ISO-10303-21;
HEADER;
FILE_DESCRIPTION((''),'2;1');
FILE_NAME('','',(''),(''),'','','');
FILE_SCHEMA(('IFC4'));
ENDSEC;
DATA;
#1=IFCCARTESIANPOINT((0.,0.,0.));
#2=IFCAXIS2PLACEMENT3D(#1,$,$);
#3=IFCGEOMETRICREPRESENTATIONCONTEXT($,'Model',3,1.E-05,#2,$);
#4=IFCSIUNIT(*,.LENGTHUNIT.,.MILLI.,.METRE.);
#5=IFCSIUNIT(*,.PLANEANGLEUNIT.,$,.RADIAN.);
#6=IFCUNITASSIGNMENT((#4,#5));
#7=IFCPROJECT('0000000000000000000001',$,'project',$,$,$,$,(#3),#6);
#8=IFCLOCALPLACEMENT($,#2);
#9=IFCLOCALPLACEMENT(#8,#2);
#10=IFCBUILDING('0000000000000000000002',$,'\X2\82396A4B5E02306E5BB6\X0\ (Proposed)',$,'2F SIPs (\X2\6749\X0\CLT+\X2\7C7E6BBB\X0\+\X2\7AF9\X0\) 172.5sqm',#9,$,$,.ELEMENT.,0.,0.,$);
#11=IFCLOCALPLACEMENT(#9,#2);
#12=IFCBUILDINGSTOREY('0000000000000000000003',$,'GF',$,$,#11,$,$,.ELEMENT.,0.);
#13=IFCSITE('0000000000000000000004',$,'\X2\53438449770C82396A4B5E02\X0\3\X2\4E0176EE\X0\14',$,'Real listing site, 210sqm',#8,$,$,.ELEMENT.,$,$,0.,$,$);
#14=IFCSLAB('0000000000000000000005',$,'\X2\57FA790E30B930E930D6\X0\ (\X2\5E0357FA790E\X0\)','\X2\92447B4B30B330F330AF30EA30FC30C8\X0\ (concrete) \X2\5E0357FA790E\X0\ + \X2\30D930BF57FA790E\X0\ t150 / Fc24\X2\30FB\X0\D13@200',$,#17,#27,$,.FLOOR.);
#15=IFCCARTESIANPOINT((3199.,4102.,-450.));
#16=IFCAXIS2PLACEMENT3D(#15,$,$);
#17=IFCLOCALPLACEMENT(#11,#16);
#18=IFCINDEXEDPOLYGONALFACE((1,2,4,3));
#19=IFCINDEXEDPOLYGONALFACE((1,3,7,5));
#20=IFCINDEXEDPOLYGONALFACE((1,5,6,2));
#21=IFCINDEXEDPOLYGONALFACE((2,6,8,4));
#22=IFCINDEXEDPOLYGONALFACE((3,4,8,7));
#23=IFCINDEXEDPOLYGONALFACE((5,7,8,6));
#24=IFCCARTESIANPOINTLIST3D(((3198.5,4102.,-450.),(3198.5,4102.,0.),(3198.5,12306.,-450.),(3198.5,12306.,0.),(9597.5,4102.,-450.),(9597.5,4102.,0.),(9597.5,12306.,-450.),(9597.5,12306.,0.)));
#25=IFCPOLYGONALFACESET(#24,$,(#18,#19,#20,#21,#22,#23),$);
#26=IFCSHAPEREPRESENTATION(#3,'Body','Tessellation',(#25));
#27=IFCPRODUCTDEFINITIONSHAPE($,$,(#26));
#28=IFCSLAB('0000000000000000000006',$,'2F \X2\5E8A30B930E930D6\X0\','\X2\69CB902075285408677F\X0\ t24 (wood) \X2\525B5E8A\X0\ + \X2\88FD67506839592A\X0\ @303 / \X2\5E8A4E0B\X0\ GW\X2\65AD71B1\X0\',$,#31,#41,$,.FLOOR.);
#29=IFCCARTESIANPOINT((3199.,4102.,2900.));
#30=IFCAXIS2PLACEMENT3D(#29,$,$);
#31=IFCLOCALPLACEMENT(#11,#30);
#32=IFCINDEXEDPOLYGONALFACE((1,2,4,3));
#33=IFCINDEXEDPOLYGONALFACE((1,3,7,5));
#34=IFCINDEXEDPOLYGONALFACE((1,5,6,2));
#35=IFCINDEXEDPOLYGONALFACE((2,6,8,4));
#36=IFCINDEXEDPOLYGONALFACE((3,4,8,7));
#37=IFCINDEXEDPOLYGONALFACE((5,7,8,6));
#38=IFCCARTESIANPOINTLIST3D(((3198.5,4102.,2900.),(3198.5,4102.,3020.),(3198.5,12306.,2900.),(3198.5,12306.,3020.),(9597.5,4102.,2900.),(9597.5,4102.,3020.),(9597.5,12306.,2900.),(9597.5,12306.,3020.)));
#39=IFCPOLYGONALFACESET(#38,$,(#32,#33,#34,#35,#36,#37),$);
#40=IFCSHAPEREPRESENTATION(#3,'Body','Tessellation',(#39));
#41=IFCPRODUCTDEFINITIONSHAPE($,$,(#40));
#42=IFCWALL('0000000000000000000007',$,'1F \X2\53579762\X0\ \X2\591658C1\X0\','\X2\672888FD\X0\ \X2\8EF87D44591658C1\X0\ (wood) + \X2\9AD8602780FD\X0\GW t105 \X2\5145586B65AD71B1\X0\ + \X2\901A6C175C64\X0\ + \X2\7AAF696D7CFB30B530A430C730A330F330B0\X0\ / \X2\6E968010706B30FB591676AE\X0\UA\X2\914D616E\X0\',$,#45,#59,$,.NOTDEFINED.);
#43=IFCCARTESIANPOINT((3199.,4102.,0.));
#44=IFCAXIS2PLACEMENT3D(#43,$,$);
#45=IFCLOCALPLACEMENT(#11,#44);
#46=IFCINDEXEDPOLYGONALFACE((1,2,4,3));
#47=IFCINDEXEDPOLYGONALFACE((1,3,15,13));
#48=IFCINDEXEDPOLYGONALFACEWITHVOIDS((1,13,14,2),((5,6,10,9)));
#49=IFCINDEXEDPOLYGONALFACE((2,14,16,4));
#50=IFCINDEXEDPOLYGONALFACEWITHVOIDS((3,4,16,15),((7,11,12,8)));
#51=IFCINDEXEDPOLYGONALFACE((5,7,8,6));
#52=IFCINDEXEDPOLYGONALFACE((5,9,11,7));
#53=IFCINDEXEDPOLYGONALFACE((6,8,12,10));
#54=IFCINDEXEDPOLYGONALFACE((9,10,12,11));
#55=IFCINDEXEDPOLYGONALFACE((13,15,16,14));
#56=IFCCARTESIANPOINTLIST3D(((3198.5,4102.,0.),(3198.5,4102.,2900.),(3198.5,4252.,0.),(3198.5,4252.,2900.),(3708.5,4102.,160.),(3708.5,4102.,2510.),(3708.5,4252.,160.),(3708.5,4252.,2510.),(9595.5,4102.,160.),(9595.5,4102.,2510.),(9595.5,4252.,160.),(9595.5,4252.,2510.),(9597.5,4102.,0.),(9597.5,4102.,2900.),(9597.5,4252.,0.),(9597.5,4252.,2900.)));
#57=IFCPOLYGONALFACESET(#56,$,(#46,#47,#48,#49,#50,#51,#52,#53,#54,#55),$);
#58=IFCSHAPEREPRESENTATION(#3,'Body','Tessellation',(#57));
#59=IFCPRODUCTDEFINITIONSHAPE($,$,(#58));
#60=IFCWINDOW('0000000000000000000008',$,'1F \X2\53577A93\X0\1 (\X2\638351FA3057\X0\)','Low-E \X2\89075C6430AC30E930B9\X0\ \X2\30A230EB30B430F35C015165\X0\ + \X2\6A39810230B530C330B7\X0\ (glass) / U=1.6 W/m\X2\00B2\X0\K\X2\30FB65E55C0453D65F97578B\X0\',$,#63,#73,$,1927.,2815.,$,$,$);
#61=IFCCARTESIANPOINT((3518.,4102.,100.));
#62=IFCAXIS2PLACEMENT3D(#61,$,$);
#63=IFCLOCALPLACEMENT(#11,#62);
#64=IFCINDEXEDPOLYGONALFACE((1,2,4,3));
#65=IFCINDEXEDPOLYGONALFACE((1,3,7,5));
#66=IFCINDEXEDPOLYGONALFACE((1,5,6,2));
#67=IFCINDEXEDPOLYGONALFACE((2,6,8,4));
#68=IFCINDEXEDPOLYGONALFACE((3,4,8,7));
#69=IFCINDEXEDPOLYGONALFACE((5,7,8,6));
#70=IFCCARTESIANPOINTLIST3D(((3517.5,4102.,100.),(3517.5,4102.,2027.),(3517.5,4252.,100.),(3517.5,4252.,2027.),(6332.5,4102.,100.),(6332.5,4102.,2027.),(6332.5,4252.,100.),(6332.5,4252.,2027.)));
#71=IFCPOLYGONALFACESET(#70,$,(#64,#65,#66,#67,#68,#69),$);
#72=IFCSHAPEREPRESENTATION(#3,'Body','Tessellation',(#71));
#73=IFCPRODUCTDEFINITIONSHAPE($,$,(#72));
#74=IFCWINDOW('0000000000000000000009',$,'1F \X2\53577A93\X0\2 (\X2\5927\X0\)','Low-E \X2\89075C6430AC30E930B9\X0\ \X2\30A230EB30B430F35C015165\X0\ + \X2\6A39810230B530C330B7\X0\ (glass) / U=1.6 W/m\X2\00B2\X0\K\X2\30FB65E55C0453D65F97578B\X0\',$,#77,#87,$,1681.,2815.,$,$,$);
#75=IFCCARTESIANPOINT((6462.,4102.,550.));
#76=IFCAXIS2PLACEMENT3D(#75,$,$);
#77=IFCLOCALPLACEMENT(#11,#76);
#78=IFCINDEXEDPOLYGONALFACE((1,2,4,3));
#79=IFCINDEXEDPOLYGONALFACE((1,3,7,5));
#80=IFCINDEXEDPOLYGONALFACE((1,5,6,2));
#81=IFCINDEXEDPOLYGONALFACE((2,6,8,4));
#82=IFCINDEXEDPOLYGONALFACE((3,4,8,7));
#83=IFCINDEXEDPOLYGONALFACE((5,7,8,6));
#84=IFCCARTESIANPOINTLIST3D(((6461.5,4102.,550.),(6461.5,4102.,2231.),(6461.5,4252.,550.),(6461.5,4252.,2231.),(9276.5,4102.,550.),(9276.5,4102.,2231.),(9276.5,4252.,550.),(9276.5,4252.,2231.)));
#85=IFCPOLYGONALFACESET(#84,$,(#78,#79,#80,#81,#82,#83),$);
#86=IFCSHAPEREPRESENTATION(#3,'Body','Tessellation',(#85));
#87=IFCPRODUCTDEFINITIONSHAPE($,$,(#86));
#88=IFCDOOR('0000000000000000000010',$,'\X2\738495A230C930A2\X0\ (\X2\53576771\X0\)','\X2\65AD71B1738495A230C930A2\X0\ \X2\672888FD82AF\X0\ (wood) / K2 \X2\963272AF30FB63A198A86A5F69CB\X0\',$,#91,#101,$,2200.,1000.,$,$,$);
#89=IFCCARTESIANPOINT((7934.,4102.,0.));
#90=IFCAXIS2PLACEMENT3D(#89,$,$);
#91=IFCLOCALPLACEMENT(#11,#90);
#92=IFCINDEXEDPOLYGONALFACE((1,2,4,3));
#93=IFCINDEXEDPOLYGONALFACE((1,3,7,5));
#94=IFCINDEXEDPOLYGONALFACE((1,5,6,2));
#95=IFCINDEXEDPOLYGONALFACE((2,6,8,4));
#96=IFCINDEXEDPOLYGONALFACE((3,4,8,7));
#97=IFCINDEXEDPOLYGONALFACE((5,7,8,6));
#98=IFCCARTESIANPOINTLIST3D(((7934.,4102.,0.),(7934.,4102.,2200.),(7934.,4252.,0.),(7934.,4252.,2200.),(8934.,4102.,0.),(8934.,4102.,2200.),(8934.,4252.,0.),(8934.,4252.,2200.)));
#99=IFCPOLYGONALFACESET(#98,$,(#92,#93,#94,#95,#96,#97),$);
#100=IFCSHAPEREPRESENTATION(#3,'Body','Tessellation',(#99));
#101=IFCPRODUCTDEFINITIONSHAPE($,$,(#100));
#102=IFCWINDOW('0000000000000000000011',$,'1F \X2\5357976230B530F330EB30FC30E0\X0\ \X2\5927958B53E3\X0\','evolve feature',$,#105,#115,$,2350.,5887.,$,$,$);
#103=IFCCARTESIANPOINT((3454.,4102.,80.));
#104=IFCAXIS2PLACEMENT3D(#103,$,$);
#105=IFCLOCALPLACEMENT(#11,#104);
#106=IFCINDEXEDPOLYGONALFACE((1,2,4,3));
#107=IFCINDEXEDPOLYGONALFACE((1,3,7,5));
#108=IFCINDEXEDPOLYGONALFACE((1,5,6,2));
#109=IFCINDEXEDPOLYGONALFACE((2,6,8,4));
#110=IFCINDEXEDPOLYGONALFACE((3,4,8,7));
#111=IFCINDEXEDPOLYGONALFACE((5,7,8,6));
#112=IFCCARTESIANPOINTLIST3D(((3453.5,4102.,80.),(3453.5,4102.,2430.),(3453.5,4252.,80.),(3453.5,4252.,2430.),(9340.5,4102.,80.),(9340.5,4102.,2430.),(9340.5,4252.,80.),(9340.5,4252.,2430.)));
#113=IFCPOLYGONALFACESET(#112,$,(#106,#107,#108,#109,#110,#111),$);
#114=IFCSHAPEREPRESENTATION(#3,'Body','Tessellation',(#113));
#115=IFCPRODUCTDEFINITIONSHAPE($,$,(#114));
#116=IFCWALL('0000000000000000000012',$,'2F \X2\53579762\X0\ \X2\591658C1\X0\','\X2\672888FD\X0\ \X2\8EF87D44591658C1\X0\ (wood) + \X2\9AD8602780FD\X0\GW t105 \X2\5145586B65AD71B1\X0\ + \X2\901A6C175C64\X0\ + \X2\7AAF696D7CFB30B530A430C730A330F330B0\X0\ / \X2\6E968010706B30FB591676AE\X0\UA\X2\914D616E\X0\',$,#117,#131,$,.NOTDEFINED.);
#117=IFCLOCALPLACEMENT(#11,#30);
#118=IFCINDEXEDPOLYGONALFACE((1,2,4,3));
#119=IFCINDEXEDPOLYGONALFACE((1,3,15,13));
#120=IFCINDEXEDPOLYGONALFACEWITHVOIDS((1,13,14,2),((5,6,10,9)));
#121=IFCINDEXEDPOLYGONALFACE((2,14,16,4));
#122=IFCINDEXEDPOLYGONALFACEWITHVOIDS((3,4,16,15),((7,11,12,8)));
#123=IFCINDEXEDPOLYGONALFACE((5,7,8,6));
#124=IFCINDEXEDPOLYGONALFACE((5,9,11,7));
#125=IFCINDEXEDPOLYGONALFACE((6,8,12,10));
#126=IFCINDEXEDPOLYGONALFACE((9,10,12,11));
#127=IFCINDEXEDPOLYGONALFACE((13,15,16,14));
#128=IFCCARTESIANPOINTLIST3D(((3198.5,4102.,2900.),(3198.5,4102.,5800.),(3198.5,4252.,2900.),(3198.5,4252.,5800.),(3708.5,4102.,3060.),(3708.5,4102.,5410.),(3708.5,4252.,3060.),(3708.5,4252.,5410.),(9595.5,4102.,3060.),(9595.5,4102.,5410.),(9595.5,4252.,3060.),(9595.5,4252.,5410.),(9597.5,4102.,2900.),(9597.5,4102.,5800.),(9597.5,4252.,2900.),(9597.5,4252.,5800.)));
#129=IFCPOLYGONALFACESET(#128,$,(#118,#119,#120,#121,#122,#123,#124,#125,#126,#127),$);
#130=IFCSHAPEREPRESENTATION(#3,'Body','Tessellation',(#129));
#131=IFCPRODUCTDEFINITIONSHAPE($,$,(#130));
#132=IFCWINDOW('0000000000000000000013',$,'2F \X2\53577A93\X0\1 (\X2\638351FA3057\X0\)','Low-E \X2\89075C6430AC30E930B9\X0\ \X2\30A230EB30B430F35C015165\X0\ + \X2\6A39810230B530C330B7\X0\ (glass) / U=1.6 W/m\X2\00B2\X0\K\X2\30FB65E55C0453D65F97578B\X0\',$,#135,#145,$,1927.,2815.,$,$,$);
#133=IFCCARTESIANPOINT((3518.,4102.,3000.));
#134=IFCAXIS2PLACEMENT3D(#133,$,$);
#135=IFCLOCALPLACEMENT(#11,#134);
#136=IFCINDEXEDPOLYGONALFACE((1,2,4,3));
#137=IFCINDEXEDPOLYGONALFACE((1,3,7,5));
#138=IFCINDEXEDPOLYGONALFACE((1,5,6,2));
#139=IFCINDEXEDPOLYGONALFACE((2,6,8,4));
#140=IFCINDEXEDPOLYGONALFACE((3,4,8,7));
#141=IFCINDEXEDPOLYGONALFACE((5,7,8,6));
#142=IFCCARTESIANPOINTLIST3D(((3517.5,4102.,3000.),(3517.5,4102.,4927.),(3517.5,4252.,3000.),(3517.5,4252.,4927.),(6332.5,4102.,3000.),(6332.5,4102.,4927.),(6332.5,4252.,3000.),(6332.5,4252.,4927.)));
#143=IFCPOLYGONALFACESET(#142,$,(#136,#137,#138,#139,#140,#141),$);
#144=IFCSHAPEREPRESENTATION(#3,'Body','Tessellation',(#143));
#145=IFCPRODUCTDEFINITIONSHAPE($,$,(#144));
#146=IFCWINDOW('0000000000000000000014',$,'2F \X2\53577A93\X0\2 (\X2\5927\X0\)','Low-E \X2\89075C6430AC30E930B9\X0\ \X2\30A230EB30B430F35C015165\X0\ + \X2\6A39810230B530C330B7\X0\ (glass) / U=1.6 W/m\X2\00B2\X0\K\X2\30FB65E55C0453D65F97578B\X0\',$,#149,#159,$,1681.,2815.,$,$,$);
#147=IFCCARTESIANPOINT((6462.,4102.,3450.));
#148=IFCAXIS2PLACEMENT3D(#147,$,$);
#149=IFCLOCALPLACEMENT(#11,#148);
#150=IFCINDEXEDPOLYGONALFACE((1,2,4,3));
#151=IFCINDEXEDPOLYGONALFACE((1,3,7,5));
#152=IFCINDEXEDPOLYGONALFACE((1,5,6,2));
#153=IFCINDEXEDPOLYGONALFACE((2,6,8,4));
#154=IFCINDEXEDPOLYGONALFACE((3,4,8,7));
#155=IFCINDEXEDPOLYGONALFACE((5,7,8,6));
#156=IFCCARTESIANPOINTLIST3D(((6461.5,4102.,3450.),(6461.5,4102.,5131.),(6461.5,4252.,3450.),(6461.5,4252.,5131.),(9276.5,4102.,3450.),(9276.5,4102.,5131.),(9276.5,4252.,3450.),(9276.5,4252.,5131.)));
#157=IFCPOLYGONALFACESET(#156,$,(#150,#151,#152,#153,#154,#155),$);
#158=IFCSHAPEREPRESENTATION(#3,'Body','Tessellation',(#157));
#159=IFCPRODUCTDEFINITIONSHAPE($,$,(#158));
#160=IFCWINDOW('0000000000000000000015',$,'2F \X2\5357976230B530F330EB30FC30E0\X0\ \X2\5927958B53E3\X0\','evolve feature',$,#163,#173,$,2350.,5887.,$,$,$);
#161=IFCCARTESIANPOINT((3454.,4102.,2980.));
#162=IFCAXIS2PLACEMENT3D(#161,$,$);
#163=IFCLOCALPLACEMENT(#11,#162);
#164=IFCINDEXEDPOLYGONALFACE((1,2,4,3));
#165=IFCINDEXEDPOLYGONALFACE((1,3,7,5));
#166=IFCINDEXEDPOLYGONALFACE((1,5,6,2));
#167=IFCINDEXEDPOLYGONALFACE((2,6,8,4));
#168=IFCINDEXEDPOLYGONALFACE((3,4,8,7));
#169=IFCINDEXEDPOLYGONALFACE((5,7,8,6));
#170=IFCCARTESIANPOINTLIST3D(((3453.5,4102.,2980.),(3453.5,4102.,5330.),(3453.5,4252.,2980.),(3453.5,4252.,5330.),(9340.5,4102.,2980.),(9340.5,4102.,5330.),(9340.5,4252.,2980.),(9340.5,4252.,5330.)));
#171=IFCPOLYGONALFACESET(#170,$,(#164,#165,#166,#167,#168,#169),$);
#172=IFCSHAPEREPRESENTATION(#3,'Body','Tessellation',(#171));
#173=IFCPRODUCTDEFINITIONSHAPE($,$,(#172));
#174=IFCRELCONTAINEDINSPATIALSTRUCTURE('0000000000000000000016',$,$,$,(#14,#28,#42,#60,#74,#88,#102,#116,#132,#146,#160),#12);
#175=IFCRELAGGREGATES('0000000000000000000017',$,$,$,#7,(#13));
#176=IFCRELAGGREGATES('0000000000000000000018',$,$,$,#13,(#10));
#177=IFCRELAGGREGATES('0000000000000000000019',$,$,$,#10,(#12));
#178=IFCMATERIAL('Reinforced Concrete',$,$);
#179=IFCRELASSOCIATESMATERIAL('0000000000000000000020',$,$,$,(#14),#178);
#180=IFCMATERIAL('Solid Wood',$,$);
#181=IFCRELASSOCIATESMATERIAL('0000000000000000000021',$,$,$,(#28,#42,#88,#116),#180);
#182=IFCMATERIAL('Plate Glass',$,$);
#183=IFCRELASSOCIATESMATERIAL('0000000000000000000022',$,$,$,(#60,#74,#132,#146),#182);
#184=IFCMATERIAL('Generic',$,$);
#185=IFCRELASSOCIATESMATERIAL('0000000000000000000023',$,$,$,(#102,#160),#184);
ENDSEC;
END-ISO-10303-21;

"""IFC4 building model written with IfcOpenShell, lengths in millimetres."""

from ifc_helpers import new_model, si_unit, frame, frame_2d, origin, place, context, project, spatial, rectangle, extrude, material, element, fill, save


model = new_model("IFC4")

# Units and contexts
model_context = context("Model", 3, precision=1e-05, world=origin())
ifc_project = project(units=[si_unit("LENGTHUNIT", "METRE", prefix="MILLI"), si_unit("PLANEANGLEUNIT", "RADIAN")], contexts=[model_context])

# Site, building, storey
site_placement = place(None, origin())
site = spatial("IfcSite", under=ifc_project, at=site_placement, Name="千葉県船橋市3丁目14", ObjectType="Real listing site, 210sqm", CompositionType="ELEMENT", RefElevation=0.0)
building_placement = place(site_placement, origin())
building = spatial("IfcBuilding", under=site, at=building_placement, Name="船橋市の家 (Proposed)", ObjectType="2F SIPs (杉CLT+籾殻+竹) 172.5sqm", CompositionType="ELEMENT", ElevationOfRefHeight=0.0, ElevationOfTerrain=0.0)
storey_placement = place(building_placement, origin())
storey = spatial("IfcBuildingStorey", under=building, at=storey_placement, Name="GF", CompositionType="ELEMENT", Elevation=0.0)

# Slabs
ifc_material_1 = material(Name="Reinforced Concrete")
slab_1_placement = place(storey_placement, frame((3199.0, 4102.0, -450.0)))
element("IfcSlab", 1, at=slab_1_placement, inside=storey, material=ifc_material_1, Name="基礎スラブ (布基礎)", Description="鉄筋コンクリート (concrete) 布基礎 + ベタ基礎 t150 / Fc24・D13@200", PredefinedType="FLOOR", context=model_context, shape_type="SweptSolid", body=[
    extrude(rectangle(XDim=6399.0, YDim=8204.0, at=frame_2d((3199.0, 4102.0))), frame((3199.0, 4102.0, -450.0)), (0.0, 0.0, 1.0), 450.0),
])
ifc_material_2 = material(Name="Solid Wood")
slab_2_placement = place(storey_placement, frame((3199.0, 4102.0, 2900.0)))
element("IfcSlab", 2, at=slab_2_placement, inside=storey, material=ifc_material_2, Name="2F 床スラブ", Description="構造用合板 t24 (wood) 剛床 + 製材根太 @303 / 床下 GW断熱", PredefinedType="FLOOR", context=model_context, shape_type="SweptSolid", body=[
    extrude(rectangle(XDim=6399.0, YDim=8204.0, at=frame_2d((3199.0, 4102.0))), frame((3199.0, 4102.0, 2900.0)), (0.0, 0.0, 1.0), 120.0),
])
ifc_material_3 = material(Name="Generic")

# Wall, openings, windows, door
wall_1_placement = place(storey_placement, frame((3199.0, 4102.0, 0.0)))
wall_1 = element("IfcWall", 3, at=wall_1_placement, inside=storey, material=ifc_material_2, Name="1F 南面 外壁", Description="木製 軸組外壁 (wood) + 高性能GW t105 充填断熱 + 通気層 + 窯業系サイディング / 準耐火・外皮UA配慮", PredefinedType="NOTDEFINED", context=model_context, shape_type="SweptSolid", body=[
    extrude(rectangle(XDim=6399.0, YDim=150.0, at=frame_2d((3199.0, 75.0))), frame((3199.0, 4102.0, 0.0)), (0.0, 0.0, 1.0), 2900.0),
])
opening_1_placement = place(storey_placement, frame((3518.0, 4102.0, 100.0)))
opening_1 = element("IfcOpeningElement", 4, at=opening_1_placement, cuts=wall_1, PredefinedType="NOTDEFINED", context=model_context, shape_type="SweptSolid", body=[
    extrude(rectangle(XDim=2815.0, YDim=150.0, at=frame_2d((1407.0, 75.0))), frame((3518.0, 4102.0, 100.0)), (0.0, 0.0, 1.0), 1927.0),
])
opening_2_placement = place(storey_placement, frame((6462.0, 4102.0, 550.0)))
opening_2 = element("IfcOpeningElement", 5, at=opening_2_placement, cuts=wall_1, PredefinedType="NOTDEFINED", context=model_context, shape_type="SweptSolid", body=[
    extrude(rectangle(XDim=2815.0, YDim=150.0, at=frame_2d((1407.0, 75.0))), frame((6462.0, 4102.0, 550.0)), (0.0, 0.0, 1.0), 1681.0),
])
opening_3_placement = place(storey_placement, frame((7934.0, 4102.0, 0.0)))
opening_3 = element("IfcOpeningElement", 6, at=opening_3_placement, cuts=wall_1, PredefinedType="NOTDEFINED", context=model_context, shape_type="SweptSolid", body=[
    extrude(rectangle(XDim=1000.0, YDim=150.0, at=frame_2d((500.0, 75.0))), frame((7934.0, 4102.0, 0.0)), (0.0, 0.0, 1.0), 2200.0),
])
opening_4_placement = place(storey_placement, frame((3454.0, 4102.0, 80.0)))
opening_4 = element("IfcOpeningElement", 7, at=opening_4_placement, cuts=wall_1, PredefinedType="NOTDEFINED", context=model_context, shape_type="SweptSolid", body=[
    extrude(rectangle(XDim=5887.0, YDim=150.0, at=frame_2d((2943.0, 75.0))), frame((3454.0, 4102.0, 80.0)), (0.0, 0.0, 1.0), 2350.0),
])
ifc_material_4 = material(Name="Plate Glass")
window_1_placement = place(storey_placement, frame((3518.0, 4102.0, 100.0)))
window_1 = element("IfcWindow", 8, at=window_1_placement, inside=storey, material=ifc_material_4, Name="1F 南窓1 (掃出し)", Description="Low-E 複層ガラス アルゴン封入 + 樹脂サッシ (glass) / U=1.6 W/m²K・日射取得型", OverallHeight=1927.0, OverallWidth=2815.0, context=model_context, shape_type="SweptSolid", body=[
    extrude(rectangle(XDim=2815.0, YDim=150.0, at=frame_2d((1407.0, 75.0))), frame((3518.0, 4102.0, 100.0)), (0.0, 0.0, 1.0), 1927.0),
])
fill(opening_1, window_1)
window_2_placement = place(storey_placement, frame((6462.0, 4102.0, 550.0)))
window_2 = element("IfcWindow", 9, at=window_2_placement, inside=storey, material=ifc_material_4, Name="1F 南窓2 (大)", Description="Low-E 複層ガラス アルゴン封入 + 樹脂サッシ (glass) / U=1.6 W/m²K・日射取得型", OverallHeight=1681.0, OverallWidth=2815.0, context=model_context, shape_type="SweptSolid", body=[
    extrude(rectangle(XDim=2815.0, YDim=150.0, at=frame_2d((1407.0, 75.0))), frame((6462.0, 4102.0, 550.0)), (0.0, 0.0, 1.0), 1681.0),
])
fill(opening_2, window_2)
door_placement = place(storey_placement, frame((7934.0, 4102.0, 0.0)))
door = element("IfcDoor", 10, at=door_placement, inside=storey, material=ifc_material_2, Name="玄関ドア (南東)", Description="断熱玄関ドア 木製芯 (wood) / K2 防犯・採風機構", OverallHeight=2200.0, OverallWidth=1000.0, context=model_context, shape_type="SweptSolid", body=[
    extrude(rectangle(XDim=1000.0, YDim=150.0, at=frame_2d((500.0, 75.0))), frame((7934.0, 4102.0, 0.0)), (0.0, 0.0, 1.0), 2200.0),
])
fill(opening_3, door)
window_3_placement = place(storey_placement, frame((3454.0, 4102.0, 80.0)))
window_3 = element("IfcWindow", 11, at=window_3_placement, inside=storey, material=ifc_material_3, Name="1F 南面サンルーム 大開口", Description="evolve feature", OverallHeight=2350.0, OverallWidth=5887.0, context=model_context, shape_type="SweptSolid", body=[
    extrude(rectangle(XDim=5887.0, YDim=150.0, at=frame_2d((2943.0, 75.0))), frame((3454.0, 4102.0, 80.0)), (0.0, 0.0, 1.0), 2350.0),
])
fill(opening_4, window_3)

# Wall, openings, windows
wall_2_placement = place(storey_placement, frame((3199.0, 4102.0, 2900.0)))
wall_2 = element("IfcWall", 12, at=wall_2_placement, inside=storey, material=ifc_material_2, Name="2F 南面 外壁", Description="木製 軸組外壁 (wood) + 高性能GW t105 充填断熱 + 通気層 + 窯業系サイディング / 準耐火・外皮UA配慮", PredefinedType="NOTDEFINED", context=model_context, shape_type="SweptSolid", body=[
    extrude(rectangle(XDim=6399.0, YDim=150.0, at=frame_2d((3199.0, 75.0))), frame((3199.0, 4102.0, 2900.0)), (0.0, 0.0, 1.0), 2900.0),
])
opening_5_placement = place(storey_placement, frame((3518.0, 4102.0, 3000.0)))
opening_5 = element("IfcOpeningElement", 13, at=opening_5_placement, cuts=wall_2, PredefinedType="NOTDEFINED", context=model_context, shape_type="SweptSolid", body=[
    extrude(rectangle(XDim=2815.0, YDim=150.0, at=frame_2d((1407.0, 75.0))), frame((3518.0, 4102.0, 3000.0)), (0.0, 0.0, 1.0), 1927.0),
])
opening_6_placement = place(storey_placement, frame((6462.0, 4102.0, 3450.0)))
opening_6 = element("IfcOpeningElement", 14, at=opening_6_placement, cuts=wall_2, PredefinedType="NOTDEFINED", context=model_context, shape_type="SweptSolid", body=[
    extrude(rectangle(XDim=2815.0, YDim=150.0, at=frame_2d((1407.0, 75.0))), frame((6462.0, 4102.0, 3450.0)), (0.0, 0.0, 1.0), 1681.0),
])
opening_7_placement = place(storey_placement, frame((3454.0, 4102.0, 2980.0)))
opening_7 = element("IfcOpeningElement", 15, at=opening_7_placement, cuts=wall_2, PredefinedType="NOTDEFINED", context=model_context, shape_type="SweptSolid", body=[
    extrude(rectangle(XDim=5887.0, YDim=150.0, at=frame_2d((2943.0, 75.0))), frame((3454.0, 4102.0, 2980.0)), (0.0, 0.0, 1.0), 2350.0),
])
window_4_placement = place(storey_placement, frame((3518.0, 4102.0, 3000.0)))
window_4 = element("IfcWindow", 16, at=window_4_placement, inside=storey, material=ifc_material_4, Name="2F 南窓1 (掃出し)", Description="Low-E 複層ガラス アルゴン封入 + 樹脂サッシ (glass) / U=1.6 W/m²K・日射取得型", OverallHeight=1927.0, OverallWidth=2815.0, context=model_context, shape_type="SweptSolid", body=[
    extrude(rectangle(XDim=2815.0, YDim=150.0, at=frame_2d((1407.0, 75.0))), frame((3518.0, 4102.0, 3000.0)), (0.0, 0.0, 1.0), 1927.0),
])
fill(opening_5, window_4)
window_5_placement = place(storey_placement, frame((6462.0, 4102.0, 3450.0)))
window_5 = element("IfcWindow", 17, at=window_5_placement, inside=storey, material=ifc_material_4, Name="2F 南窓2 (大)", Description="Low-E 複層ガラス アルゴン封入 + 樹脂サッシ (glass) / U=1.6 W/m²K・日射取得型", OverallHeight=1681.0, OverallWidth=2815.0, context=model_context, shape_type="SweptSolid", body=[
    extrude(rectangle(XDim=2815.0, YDim=150.0, at=frame_2d((1407.0, 75.0))), frame((6462.0, 4102.0, 3450.0)), (0.0, 0.0, 1.0), 1681.0),
])
fill(opening_6, window_5)
window_6_placement = place(storey_placement, frame((3454.0, 4102.0, 2980.0)))
window_6 = element("IfcWindow", 18, at=window_6_placement, inside=storey, material=ifc_material_3, Name="2F 南面サンルーム 大開口", Description="evolve feature", OverallHeight=2350.0, OverallWidth=5887.0, context=model_context, shape_type="SweptSolid", body=[
    extrude(rectangle(XDim=5887.0, YDim=150.0, at=frame_2d((2943.0, 75.0))), frame((3454.0, 4102.0, 2980.0)), (0.0, 0.0, 1.0), 2350.0),
])
fill(opening_7, window_6)

save(model, "model.ifc")
